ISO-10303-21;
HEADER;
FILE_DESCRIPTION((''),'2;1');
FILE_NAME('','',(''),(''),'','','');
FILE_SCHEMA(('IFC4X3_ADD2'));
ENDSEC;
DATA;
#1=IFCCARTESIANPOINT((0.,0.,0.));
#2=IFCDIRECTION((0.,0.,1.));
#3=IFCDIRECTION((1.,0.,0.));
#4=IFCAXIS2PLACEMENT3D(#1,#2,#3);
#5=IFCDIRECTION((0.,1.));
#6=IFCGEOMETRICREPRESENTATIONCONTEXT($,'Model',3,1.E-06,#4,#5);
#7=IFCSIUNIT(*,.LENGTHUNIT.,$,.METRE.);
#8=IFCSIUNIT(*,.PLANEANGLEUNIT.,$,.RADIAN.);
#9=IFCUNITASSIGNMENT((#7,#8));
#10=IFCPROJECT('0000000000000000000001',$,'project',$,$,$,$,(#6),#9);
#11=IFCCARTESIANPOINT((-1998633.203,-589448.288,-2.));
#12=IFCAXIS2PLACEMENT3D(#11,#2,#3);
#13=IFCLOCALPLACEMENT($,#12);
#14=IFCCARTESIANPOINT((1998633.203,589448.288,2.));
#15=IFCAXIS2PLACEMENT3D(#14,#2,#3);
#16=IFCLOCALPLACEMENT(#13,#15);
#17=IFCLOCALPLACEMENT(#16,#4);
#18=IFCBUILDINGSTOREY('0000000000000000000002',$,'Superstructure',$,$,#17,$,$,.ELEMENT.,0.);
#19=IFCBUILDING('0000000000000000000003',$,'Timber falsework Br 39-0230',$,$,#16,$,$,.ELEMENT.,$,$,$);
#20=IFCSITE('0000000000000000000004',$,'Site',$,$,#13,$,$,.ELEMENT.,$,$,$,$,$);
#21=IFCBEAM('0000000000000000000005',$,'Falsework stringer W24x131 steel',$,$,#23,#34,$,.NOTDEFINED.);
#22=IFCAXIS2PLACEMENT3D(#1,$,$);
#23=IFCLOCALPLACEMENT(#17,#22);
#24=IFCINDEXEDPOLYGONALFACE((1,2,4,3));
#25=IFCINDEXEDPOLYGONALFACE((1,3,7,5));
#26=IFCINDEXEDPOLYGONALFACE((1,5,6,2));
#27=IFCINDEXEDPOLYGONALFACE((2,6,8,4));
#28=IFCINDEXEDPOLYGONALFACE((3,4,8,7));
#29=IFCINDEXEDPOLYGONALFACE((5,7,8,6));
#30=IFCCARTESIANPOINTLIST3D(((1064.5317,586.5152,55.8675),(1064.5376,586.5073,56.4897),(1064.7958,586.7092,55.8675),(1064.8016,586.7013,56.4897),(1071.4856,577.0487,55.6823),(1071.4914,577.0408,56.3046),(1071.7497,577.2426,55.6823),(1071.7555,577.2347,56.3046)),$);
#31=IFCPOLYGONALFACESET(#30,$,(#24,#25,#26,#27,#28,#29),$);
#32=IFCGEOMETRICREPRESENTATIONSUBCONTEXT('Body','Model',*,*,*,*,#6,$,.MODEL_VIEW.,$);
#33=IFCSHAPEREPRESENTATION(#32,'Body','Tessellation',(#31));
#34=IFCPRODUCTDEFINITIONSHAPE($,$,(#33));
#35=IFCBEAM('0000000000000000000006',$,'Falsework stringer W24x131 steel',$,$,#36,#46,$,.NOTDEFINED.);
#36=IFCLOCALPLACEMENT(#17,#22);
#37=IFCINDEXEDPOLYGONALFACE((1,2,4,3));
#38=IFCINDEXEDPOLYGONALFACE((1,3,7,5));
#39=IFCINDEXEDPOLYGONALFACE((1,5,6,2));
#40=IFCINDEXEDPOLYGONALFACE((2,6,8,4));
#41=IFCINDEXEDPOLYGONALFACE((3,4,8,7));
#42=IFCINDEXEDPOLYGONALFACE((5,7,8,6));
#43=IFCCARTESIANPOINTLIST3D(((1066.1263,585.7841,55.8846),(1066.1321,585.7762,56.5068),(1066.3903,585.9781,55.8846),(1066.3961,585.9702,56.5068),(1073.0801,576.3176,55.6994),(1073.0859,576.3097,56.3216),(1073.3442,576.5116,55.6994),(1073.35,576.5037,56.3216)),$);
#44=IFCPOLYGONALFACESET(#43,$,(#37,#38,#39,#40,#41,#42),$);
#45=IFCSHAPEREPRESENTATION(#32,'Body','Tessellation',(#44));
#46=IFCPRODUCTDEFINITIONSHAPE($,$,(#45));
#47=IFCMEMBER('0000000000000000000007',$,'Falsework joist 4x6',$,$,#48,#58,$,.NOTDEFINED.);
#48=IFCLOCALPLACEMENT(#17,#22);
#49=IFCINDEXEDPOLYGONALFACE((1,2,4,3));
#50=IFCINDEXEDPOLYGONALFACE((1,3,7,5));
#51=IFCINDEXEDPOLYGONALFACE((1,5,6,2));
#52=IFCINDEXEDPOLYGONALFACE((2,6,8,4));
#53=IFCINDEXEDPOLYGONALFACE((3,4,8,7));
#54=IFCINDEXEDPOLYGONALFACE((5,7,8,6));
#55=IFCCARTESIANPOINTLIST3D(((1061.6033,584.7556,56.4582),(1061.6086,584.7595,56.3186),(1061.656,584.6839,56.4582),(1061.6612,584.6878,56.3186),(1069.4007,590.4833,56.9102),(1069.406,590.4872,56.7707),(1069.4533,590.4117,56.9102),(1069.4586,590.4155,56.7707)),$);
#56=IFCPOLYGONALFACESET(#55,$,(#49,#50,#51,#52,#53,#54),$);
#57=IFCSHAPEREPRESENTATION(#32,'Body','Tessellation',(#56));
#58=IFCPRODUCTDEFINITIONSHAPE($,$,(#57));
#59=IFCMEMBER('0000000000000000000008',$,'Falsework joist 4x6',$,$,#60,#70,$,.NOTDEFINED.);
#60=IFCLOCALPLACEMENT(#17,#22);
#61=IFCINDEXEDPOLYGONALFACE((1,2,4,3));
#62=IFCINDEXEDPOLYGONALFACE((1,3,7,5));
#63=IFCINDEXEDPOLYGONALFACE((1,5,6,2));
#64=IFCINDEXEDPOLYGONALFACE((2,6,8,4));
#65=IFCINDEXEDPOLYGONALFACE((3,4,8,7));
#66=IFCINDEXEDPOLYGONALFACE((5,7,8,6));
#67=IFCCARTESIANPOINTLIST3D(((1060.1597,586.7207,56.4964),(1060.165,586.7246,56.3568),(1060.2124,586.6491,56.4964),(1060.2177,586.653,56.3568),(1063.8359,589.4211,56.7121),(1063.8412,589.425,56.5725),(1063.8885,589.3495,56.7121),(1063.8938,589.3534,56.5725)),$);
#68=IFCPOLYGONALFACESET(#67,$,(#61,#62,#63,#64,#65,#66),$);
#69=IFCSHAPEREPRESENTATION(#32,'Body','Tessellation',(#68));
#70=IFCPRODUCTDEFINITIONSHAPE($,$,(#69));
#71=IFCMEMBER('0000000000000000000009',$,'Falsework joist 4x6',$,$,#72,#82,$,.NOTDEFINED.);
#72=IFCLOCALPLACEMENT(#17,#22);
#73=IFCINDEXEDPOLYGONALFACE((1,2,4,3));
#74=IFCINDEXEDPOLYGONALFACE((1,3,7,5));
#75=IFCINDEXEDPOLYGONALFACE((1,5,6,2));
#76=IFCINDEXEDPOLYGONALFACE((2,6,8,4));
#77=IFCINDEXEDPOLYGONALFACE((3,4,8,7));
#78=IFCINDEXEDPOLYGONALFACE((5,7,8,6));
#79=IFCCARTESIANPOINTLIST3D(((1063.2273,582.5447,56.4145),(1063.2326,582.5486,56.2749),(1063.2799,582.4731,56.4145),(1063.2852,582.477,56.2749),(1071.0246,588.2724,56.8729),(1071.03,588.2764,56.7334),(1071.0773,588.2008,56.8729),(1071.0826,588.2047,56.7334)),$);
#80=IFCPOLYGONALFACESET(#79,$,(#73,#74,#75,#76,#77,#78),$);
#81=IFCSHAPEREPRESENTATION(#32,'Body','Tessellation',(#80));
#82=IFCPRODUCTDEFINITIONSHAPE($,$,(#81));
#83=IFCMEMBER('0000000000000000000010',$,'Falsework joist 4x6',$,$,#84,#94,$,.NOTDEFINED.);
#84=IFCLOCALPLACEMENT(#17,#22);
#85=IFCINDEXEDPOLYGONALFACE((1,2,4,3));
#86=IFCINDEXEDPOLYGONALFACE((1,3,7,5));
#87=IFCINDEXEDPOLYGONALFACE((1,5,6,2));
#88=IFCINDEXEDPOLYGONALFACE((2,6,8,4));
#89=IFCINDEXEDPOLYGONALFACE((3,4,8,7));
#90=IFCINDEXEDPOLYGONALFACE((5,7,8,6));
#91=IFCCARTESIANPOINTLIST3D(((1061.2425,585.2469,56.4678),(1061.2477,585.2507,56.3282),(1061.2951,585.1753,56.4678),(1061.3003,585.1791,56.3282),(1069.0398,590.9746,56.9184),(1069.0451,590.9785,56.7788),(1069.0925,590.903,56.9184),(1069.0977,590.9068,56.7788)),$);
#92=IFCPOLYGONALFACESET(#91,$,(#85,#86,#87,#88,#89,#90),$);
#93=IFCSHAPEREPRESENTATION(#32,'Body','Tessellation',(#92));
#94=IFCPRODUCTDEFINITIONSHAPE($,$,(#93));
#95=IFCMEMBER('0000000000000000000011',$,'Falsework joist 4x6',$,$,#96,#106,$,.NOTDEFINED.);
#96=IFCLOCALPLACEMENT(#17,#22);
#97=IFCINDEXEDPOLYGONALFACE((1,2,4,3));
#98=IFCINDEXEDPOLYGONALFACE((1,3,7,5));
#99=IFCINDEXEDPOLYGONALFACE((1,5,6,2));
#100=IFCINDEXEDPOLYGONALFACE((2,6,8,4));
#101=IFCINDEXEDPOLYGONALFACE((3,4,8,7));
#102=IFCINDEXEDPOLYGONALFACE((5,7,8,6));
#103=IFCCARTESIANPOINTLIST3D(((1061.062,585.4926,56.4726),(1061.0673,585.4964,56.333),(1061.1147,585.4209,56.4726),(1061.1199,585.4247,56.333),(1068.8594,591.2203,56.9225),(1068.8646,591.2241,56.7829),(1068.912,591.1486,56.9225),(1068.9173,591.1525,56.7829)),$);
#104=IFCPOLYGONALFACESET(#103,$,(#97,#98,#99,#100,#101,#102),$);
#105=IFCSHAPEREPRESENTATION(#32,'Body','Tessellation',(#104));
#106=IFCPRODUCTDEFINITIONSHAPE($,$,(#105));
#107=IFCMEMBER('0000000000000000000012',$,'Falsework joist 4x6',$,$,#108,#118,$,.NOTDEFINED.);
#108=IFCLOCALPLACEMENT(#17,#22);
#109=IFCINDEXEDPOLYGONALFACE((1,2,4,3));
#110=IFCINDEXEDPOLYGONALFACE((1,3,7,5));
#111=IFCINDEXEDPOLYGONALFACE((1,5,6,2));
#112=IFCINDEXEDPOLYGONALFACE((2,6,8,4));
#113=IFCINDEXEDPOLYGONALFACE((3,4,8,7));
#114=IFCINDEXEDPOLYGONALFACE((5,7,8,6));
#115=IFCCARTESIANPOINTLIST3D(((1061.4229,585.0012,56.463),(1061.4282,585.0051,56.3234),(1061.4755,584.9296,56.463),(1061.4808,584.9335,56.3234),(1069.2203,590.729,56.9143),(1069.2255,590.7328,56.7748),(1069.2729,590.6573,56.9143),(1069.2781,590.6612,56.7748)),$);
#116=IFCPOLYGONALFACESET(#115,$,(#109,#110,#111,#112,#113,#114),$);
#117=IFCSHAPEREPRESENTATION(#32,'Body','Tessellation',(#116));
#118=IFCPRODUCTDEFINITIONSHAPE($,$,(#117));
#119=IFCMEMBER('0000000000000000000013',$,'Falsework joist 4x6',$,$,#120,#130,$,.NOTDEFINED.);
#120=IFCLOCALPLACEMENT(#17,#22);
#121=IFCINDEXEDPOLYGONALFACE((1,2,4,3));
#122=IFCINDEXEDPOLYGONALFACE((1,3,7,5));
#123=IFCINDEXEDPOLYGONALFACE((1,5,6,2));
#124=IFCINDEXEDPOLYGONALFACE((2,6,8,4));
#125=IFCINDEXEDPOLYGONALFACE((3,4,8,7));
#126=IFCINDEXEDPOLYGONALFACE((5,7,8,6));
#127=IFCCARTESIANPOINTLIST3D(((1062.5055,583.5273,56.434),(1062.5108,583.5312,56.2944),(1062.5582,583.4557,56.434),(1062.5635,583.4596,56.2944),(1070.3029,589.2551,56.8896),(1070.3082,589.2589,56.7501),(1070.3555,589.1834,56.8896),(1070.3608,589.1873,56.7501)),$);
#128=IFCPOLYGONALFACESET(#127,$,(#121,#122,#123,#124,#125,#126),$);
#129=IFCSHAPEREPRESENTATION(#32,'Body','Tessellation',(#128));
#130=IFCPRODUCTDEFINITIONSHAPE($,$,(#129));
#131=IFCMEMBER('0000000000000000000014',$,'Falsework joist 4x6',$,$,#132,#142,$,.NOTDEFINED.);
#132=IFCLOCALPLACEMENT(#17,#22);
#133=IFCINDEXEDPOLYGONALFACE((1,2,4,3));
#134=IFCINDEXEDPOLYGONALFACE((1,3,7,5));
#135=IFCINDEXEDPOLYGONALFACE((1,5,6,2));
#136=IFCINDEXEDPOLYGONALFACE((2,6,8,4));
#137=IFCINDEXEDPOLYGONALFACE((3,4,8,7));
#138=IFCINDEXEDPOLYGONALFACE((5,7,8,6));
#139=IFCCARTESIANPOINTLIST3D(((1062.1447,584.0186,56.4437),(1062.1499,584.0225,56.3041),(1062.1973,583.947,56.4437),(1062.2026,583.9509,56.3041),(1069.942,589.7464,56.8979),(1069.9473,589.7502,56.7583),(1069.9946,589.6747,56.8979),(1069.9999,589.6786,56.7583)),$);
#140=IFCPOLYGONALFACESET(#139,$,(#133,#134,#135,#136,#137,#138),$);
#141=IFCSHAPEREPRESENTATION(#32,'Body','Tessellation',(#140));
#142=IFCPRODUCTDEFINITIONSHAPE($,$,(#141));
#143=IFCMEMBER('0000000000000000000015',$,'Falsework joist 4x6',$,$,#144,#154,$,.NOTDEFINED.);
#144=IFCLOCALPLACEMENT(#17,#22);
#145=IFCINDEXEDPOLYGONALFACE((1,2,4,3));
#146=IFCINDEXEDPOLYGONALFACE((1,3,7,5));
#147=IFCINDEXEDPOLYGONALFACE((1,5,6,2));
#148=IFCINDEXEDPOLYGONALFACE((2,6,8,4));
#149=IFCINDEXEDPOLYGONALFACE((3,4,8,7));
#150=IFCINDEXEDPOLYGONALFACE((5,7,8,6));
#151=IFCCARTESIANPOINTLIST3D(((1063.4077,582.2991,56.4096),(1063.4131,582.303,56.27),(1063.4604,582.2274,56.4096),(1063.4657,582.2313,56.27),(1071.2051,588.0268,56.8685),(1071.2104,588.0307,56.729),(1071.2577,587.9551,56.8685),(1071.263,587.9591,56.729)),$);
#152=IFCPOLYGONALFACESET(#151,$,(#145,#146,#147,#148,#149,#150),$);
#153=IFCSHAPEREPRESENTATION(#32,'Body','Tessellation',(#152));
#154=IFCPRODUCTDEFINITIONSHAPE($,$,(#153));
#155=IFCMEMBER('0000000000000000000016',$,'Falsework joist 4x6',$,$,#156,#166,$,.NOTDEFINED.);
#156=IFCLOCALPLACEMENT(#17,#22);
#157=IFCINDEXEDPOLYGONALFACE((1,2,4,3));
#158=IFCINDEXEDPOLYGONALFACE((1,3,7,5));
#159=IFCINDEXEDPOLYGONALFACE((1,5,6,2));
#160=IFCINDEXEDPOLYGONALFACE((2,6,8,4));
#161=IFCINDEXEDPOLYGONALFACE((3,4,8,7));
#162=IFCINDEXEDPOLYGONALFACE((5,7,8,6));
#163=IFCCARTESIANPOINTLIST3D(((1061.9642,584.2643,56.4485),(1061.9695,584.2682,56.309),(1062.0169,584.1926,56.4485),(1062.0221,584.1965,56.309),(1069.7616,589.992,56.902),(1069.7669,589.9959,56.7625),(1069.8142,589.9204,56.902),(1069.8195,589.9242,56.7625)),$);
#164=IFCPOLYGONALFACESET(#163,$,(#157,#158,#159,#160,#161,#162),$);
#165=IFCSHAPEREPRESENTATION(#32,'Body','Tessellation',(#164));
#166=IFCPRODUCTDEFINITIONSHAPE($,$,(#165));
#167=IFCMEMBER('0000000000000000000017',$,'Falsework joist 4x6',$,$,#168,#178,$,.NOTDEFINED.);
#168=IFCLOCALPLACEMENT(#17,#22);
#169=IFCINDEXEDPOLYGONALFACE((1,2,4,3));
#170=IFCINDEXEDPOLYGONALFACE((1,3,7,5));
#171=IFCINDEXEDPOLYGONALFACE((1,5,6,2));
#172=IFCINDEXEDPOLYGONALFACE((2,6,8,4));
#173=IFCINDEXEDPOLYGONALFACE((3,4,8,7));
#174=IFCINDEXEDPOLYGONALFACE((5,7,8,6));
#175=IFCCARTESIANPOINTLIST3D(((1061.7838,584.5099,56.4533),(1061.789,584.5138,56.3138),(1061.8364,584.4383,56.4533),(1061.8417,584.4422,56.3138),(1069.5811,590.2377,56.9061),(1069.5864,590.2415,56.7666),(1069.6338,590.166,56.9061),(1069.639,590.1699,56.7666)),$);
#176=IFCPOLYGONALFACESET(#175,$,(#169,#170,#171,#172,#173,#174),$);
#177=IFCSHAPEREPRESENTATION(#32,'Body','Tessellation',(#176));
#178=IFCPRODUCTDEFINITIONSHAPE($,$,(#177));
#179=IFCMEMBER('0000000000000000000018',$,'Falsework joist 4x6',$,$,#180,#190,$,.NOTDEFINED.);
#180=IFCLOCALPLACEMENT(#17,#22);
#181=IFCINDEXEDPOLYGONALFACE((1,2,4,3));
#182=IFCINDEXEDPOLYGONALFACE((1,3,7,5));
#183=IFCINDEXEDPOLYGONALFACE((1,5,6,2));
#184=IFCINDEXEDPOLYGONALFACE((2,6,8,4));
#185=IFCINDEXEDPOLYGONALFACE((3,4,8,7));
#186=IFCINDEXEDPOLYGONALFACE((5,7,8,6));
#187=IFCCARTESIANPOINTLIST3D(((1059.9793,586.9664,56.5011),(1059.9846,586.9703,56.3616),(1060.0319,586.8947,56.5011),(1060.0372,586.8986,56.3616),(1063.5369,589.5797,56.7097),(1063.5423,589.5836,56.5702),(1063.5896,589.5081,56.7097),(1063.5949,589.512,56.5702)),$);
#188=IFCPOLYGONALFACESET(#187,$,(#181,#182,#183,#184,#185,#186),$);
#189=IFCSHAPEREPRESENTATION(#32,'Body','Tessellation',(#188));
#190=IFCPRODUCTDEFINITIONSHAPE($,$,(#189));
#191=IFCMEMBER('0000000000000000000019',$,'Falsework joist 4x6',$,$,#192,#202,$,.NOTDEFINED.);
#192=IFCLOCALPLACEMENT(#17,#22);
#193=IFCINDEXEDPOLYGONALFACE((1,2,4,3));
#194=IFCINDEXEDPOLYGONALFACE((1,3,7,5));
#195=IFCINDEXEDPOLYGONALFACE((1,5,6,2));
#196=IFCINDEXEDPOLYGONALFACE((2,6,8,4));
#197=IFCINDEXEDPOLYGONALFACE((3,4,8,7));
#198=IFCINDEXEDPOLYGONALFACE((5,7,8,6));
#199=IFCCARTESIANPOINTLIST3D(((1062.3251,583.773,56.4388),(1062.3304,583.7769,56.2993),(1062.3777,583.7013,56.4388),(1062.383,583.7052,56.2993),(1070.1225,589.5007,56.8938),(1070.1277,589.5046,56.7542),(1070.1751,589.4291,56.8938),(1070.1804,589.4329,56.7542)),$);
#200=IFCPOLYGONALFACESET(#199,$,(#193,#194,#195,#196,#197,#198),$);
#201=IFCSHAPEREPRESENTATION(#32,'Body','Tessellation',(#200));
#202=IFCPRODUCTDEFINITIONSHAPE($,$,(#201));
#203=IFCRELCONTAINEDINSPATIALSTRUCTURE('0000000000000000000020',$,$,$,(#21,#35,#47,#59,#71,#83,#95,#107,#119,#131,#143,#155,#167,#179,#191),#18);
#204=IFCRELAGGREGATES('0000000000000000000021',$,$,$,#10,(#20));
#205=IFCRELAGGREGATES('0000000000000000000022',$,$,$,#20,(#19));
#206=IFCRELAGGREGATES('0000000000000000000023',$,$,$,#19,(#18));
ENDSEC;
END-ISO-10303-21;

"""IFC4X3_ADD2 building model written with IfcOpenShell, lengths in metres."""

from ifc_helpers import new_model, si_unit, direction, frame, frame_2d, origin, origin_with_axes, place, context, subcontext, project, spatial, rectangle, extrude, element, save


model = new_model("IFC4X3_ADD2")

# Units and contexts
model_context = context("Model", 3, precision=1e-06, world=origin_with_axes(), true_north=direction((0.0, 1.0)))
body_context = subcontext(model_context, "Body", "Model", "MODEL_VIEW")
ifc_project = project(units=[si_unit("LENGTHUNIT", "METRE"), si_unit("PLANEANGLEUNIT", "RADIAN")], contexts=[model_context])

# Site, building, storey
site_placement = place(None, frame((-1998633.203, -589448.288, -2.0), z_axis=(0.0, 0.0, 1.0), x_axis=(1.0, 0.0, 0.0)))
site = spatial("IfcSite", under=ifc_project, at=site_placement, Name="Site", CompositionType="ELEMENT")
building_placement = place(site_placement, frame((1998633.203, 589448.288, 2.0), z_axis=(0.0, 0.0, 1.0), x_axis=(1.0, 0.0, 0.0)))
building = spatial("IfcBuilding", under=site, at=building_placement, Name="Timber falsework Br 39-0230", CompositionType="ELEMENT")
storey_placement = place(building_placement, origin_with_axes())
storey = spatial("IfcBuildingStorey", under=building, at=storey_placement, Name="Superstructure", CompositionType="ELEMENT", Elevation=0.0)

# Beams
beam_1_placement = place(storey_placement, frame((1064.6638, 586.6122, 55.8675), z_axis=(0.59194, -0.805828, -0.015763), x_axis=(0.805928, 0.592013, 0.0)))
element("IfcBeam", 1, at=beam_1_placement, inside=storey, Name="Falsework stringer W24x131 steel", PredefinedType="NOTDEFINED", context=body_context, shape_type="SweptSolid", body=[
    extrude(rectangle(XDim=0.3277, YDim=0.6223, at=frame_2d((0.0, 0.3111))), origin(), (0.0, 0.0, 1.0), 11.7476),
])
beam_2_placement = place(storey_placement, frame((1066.2583, 585.8811, 55.8846), z_axis=(0.59194, -0.805828, -0.015763), x_axis=(0.805928, 0.592013, 0.0)))
element("IfcBeam", 2, at=beam_2_placement, inside=storey, Name="Falsework stringer W24x131 steel", PredefinedType="NOTDEFINED", context=body_context, shape_type="SweptSolid", body=[
    extrude(rectangle(XDim=0.3277, YDim=0.6223, at=frame_2d((0.0, 0.3111))), origin(), (0.0, 0.0, 1.0), 11.7476),
])

# Members
member_1_placement = place(storey_placement, frame((1061.6349, 584.7236, 56.3186), z_axis=(0.80505, 0.591368, 0.046673), x_axis=(-0.592013, 0.805928, 0.0)))
element("IfcMember", 3, at=member_1_placement, inside=storey, Name="Falsework joist 4x6", PredefinedType="NOTDEFINED", context=body_context, shape_type="SweptSolid", body=[
    extrude(rectangle(XDim=0.0889, YDim=0.1397, at=frame_2d((0.0, 0.0698))), origin(), (0.0, 0.0, 1.0), 9.6856),
])
member_2_placement = place(storey_placement, frame((1060.1914, 586.6888, 56.3568), z_axis=(0.805029, 0.591352, 0.047233), x_axis=(-0.592013, 0.805928, 0.0)))
element("IfcMember", 4, at=member_2_placement, inside=storey, Name="Falsework joist 4x6", PredefinedType="NOTDEFINED", context=body_context, shape_type="SweptSolid", body=[
    extrude(rectangle(XDim=0.0889, YDim=0.1397, at=frame_2d((0.0, 0.0698))), origin(), (0.0, 0.0, 1.0), 4.5665),
])
member_3_placement = place(storey_placement, frame((1063.2589, 582.5128, 56.2749), z_axis=(0.805025, 0.59135, 0.047332), x_axis=(-0.592013, 0.805928, 0.0)))
element("IfcMember", 5, at=member_3_placement, inside=storey, Name="Falsework joist 4x6", PredefinedType="NOTDEFINED", context=body_context, shape_type="SweptSolid", body=[
    extrude(rectangle(XDim=0.0889, YDim=0.1397, at=frame_2d((0.0, 0.0698))), origin(), (0.0, 0.0, 1.0), 9.6859),
])
member_4_placement = place(storey_placement, frame((1061.274, 585.2149, 56.3282), z_axis=(0.805056, 0.591372, 0.046525), x_axis=(-0.592013, 0.805928, 0.0)))
element("IfcMember", 6, at=member_4_placement, inside=storey, Name="Falsework joist 4x6", PredefinedType="NOTDEFINED", context=body_context, shape_type="SweptSolid", body=[
    extrude(rectangle(XDim=0.0889, YDim=0.1397, at=frame_2d((0.0, 0.0698))), origin(), (0.0, 0.0, 1.0), 9.6855),
])
member_5_placement = place(storey_placement, frame((1061.0936, 585.4606, 56.333), z_axis=(0.805058, 0.591374, 0.046451), x_axis=(-0.592013, 0.805928, 0.0)))
element("IfcMember", 7, at=member_5_placement, inside=storey, Name="Falsework joist 4x6", PredefinedType="NOTDEFINED", context=body_context, shape_type="SweptSolid", body=[
    extrude(rectangle(XDim=0.0889, YDim=0.1397, at=frame_2d((0.0, 0.0698))), origin(), (0.0, 0.0, 1.0), 9.6855),
])
member_6_placement = place(storey_placement, frame((1061.4545, 584.9693, 56.3234), z_axis=(0.805053, 0.59137, 0.046599), x_axis=(-0.592013, 0.805928, 0.0)))
element("IfcMember", 8, at=member_6_placement, inside=storey, Name="Falsework joist 4x6", PredefinedType="NOTDEFINED", context=body_context, shape_type="SweptSolid", body=[
    extrude(rectangle(XDim=0.0889, YDim=0.1397, at=frame_2d((0.0, 0.0698))), origin(), (0.0, 0.0, 1.0), 9.6855),
])
member_7_placement = place(storey_placement, frame((1062.5371, 583.4954, 56.2944), z_axis=(0.805036, 0.591358, 0.047043), x_axis=(-0.592013, 0.805928, 0.0)))
element("IfcMember", 9, at=member_7_placement, inside=storey, Name="Falsework joist 4x6", PredefinedType="NOTDEFINED", context=body_context, shape_type="SweptSolid", body=[
    extrude(rectangle(XDim=0.0889, YDim=0.1397, at=frame_2d((0.0, 0.0698))), origin(), (0.0, 0.0, 1.0), 9.6857),
])
member_8_placement = place(storey_placement, frame((1062.1763, 583.9867, 56.3041), z_axis=(0.805042, 0.591362, 0.046895), x_axis=(-0.592013, 0.805928, 0.0)))
element("IfcMember", 10, at=member_8_placement, inside=storey, Name="Falsework joist 4x6", PredefinedType="NOTDEFINED", context=body_context, shape_type="SweptSolid", body=[
    extrude(rectangle(XDim=0.0889, YDim=0.1397, at=frame_2d((0.0, 0.0698))), origin(), (0.0, 0.0, 1.0), 9.6857),
])
member_9_placement = place(storey_placement, frame((1063.4394, 582.2672, 56.27), z_axis=(0.805023, 0.591348, 0.047384), x_axis=(-0.592013, 0.805928, 0.0)))
element("IfcMember", 11, at=member_9_placement, inside=storey, Name="Falsework joist 4x6", PredefinedType="NOTDEFINED", context=body_context, shape_type="SweptSolid", body=[
    extrude(rectangle(XDim=0.0889, YDim=0.1397, at=frame_2d((0.0, 0.0698))), origin(), (0.0, 0.0, 1.0), 9.6859),
])
member_10_placement = place(storey_placement, frame((1061.9958, 584.2323, 56.309), z_axis=(0.805044, 0.591364, 0.046821), x_axis=(-0.592013, 0.805928, 0.0)))
element("IfcMember", 12, at=member_10_placement, inside=storey, Name="Falsework joist 4x6", PredefinedType="NOTDEFINED", context=body_context, shape_type="SweptSolid", body=[
    extrude(rectangle(XDim=0.0889, YDim=0.1397, at=frame_2d((0.0, 0.0698))), origin(), (0.0, 0.0, 1.0), 9.6856),
])
member_11_placement = place(storey_placement, frame((1061.8154, 584.478, 56.3138), z_axis=(0.805047, 0.591366, 0.046747), x_axis=(-0.592013, 0.805928, 0.0)))
element("IfcMember", 13, at=member_11_placement, inside=storey, Name="Falsework joist 4x6", PredefinedType="NOTDEFINED", context=body_context, shape_type="SweptSolid", body=[
    extrude(rectangle(XDim=0.0889, YDim=0.1397, at=frame_2d((0.0, 0.0698))), origin(), (0.0, 0.0, 1.0), 9.6856),
])
member_12_placement = place(storey_placement, frame((1060.0109, 586.9345, 56.3616), z_axis=(0.80503, 0.591353, 0.047203), x_axis=(-0.592013, 0.805928, 0.0)))
element("IfcMember", 14, at=member_12_placement, inside=storey, Name="Falsework joist 4x6", PredefinedType="NOTDEFINED", context=body_context, shape_type="SweptSolid", body=[
    extrude(rectangle(XDim=0.0889, YDim=0.1397, at=frame_2d((0.0, 0.0698))), origin(), (0.0, 0.0, 1.0), 4.4193),
])
member_13_placement = place(storey_placement, frame((1062.3567, 583.741, 56.2993), z_axis=(0.805039, 0.59136, 0.046969), x_axis=(-0.592013, 0.805928, 0.0)))
element("IfcMember", 15, at=member_13_placement, inside=storey, Name="Falsework joist 4x6", PredefinedType="NOTDEFINED", context=body_context, shape_type="SweptSolid", body=[
    extrude(rectangle(XDim=0.0889, YDim=0.1397, at=frame_2d((0.0, 0.0698))), origin(), (0.0, 0.0, 1.0), 9.6857),
])

save(model, "model.ifc")
